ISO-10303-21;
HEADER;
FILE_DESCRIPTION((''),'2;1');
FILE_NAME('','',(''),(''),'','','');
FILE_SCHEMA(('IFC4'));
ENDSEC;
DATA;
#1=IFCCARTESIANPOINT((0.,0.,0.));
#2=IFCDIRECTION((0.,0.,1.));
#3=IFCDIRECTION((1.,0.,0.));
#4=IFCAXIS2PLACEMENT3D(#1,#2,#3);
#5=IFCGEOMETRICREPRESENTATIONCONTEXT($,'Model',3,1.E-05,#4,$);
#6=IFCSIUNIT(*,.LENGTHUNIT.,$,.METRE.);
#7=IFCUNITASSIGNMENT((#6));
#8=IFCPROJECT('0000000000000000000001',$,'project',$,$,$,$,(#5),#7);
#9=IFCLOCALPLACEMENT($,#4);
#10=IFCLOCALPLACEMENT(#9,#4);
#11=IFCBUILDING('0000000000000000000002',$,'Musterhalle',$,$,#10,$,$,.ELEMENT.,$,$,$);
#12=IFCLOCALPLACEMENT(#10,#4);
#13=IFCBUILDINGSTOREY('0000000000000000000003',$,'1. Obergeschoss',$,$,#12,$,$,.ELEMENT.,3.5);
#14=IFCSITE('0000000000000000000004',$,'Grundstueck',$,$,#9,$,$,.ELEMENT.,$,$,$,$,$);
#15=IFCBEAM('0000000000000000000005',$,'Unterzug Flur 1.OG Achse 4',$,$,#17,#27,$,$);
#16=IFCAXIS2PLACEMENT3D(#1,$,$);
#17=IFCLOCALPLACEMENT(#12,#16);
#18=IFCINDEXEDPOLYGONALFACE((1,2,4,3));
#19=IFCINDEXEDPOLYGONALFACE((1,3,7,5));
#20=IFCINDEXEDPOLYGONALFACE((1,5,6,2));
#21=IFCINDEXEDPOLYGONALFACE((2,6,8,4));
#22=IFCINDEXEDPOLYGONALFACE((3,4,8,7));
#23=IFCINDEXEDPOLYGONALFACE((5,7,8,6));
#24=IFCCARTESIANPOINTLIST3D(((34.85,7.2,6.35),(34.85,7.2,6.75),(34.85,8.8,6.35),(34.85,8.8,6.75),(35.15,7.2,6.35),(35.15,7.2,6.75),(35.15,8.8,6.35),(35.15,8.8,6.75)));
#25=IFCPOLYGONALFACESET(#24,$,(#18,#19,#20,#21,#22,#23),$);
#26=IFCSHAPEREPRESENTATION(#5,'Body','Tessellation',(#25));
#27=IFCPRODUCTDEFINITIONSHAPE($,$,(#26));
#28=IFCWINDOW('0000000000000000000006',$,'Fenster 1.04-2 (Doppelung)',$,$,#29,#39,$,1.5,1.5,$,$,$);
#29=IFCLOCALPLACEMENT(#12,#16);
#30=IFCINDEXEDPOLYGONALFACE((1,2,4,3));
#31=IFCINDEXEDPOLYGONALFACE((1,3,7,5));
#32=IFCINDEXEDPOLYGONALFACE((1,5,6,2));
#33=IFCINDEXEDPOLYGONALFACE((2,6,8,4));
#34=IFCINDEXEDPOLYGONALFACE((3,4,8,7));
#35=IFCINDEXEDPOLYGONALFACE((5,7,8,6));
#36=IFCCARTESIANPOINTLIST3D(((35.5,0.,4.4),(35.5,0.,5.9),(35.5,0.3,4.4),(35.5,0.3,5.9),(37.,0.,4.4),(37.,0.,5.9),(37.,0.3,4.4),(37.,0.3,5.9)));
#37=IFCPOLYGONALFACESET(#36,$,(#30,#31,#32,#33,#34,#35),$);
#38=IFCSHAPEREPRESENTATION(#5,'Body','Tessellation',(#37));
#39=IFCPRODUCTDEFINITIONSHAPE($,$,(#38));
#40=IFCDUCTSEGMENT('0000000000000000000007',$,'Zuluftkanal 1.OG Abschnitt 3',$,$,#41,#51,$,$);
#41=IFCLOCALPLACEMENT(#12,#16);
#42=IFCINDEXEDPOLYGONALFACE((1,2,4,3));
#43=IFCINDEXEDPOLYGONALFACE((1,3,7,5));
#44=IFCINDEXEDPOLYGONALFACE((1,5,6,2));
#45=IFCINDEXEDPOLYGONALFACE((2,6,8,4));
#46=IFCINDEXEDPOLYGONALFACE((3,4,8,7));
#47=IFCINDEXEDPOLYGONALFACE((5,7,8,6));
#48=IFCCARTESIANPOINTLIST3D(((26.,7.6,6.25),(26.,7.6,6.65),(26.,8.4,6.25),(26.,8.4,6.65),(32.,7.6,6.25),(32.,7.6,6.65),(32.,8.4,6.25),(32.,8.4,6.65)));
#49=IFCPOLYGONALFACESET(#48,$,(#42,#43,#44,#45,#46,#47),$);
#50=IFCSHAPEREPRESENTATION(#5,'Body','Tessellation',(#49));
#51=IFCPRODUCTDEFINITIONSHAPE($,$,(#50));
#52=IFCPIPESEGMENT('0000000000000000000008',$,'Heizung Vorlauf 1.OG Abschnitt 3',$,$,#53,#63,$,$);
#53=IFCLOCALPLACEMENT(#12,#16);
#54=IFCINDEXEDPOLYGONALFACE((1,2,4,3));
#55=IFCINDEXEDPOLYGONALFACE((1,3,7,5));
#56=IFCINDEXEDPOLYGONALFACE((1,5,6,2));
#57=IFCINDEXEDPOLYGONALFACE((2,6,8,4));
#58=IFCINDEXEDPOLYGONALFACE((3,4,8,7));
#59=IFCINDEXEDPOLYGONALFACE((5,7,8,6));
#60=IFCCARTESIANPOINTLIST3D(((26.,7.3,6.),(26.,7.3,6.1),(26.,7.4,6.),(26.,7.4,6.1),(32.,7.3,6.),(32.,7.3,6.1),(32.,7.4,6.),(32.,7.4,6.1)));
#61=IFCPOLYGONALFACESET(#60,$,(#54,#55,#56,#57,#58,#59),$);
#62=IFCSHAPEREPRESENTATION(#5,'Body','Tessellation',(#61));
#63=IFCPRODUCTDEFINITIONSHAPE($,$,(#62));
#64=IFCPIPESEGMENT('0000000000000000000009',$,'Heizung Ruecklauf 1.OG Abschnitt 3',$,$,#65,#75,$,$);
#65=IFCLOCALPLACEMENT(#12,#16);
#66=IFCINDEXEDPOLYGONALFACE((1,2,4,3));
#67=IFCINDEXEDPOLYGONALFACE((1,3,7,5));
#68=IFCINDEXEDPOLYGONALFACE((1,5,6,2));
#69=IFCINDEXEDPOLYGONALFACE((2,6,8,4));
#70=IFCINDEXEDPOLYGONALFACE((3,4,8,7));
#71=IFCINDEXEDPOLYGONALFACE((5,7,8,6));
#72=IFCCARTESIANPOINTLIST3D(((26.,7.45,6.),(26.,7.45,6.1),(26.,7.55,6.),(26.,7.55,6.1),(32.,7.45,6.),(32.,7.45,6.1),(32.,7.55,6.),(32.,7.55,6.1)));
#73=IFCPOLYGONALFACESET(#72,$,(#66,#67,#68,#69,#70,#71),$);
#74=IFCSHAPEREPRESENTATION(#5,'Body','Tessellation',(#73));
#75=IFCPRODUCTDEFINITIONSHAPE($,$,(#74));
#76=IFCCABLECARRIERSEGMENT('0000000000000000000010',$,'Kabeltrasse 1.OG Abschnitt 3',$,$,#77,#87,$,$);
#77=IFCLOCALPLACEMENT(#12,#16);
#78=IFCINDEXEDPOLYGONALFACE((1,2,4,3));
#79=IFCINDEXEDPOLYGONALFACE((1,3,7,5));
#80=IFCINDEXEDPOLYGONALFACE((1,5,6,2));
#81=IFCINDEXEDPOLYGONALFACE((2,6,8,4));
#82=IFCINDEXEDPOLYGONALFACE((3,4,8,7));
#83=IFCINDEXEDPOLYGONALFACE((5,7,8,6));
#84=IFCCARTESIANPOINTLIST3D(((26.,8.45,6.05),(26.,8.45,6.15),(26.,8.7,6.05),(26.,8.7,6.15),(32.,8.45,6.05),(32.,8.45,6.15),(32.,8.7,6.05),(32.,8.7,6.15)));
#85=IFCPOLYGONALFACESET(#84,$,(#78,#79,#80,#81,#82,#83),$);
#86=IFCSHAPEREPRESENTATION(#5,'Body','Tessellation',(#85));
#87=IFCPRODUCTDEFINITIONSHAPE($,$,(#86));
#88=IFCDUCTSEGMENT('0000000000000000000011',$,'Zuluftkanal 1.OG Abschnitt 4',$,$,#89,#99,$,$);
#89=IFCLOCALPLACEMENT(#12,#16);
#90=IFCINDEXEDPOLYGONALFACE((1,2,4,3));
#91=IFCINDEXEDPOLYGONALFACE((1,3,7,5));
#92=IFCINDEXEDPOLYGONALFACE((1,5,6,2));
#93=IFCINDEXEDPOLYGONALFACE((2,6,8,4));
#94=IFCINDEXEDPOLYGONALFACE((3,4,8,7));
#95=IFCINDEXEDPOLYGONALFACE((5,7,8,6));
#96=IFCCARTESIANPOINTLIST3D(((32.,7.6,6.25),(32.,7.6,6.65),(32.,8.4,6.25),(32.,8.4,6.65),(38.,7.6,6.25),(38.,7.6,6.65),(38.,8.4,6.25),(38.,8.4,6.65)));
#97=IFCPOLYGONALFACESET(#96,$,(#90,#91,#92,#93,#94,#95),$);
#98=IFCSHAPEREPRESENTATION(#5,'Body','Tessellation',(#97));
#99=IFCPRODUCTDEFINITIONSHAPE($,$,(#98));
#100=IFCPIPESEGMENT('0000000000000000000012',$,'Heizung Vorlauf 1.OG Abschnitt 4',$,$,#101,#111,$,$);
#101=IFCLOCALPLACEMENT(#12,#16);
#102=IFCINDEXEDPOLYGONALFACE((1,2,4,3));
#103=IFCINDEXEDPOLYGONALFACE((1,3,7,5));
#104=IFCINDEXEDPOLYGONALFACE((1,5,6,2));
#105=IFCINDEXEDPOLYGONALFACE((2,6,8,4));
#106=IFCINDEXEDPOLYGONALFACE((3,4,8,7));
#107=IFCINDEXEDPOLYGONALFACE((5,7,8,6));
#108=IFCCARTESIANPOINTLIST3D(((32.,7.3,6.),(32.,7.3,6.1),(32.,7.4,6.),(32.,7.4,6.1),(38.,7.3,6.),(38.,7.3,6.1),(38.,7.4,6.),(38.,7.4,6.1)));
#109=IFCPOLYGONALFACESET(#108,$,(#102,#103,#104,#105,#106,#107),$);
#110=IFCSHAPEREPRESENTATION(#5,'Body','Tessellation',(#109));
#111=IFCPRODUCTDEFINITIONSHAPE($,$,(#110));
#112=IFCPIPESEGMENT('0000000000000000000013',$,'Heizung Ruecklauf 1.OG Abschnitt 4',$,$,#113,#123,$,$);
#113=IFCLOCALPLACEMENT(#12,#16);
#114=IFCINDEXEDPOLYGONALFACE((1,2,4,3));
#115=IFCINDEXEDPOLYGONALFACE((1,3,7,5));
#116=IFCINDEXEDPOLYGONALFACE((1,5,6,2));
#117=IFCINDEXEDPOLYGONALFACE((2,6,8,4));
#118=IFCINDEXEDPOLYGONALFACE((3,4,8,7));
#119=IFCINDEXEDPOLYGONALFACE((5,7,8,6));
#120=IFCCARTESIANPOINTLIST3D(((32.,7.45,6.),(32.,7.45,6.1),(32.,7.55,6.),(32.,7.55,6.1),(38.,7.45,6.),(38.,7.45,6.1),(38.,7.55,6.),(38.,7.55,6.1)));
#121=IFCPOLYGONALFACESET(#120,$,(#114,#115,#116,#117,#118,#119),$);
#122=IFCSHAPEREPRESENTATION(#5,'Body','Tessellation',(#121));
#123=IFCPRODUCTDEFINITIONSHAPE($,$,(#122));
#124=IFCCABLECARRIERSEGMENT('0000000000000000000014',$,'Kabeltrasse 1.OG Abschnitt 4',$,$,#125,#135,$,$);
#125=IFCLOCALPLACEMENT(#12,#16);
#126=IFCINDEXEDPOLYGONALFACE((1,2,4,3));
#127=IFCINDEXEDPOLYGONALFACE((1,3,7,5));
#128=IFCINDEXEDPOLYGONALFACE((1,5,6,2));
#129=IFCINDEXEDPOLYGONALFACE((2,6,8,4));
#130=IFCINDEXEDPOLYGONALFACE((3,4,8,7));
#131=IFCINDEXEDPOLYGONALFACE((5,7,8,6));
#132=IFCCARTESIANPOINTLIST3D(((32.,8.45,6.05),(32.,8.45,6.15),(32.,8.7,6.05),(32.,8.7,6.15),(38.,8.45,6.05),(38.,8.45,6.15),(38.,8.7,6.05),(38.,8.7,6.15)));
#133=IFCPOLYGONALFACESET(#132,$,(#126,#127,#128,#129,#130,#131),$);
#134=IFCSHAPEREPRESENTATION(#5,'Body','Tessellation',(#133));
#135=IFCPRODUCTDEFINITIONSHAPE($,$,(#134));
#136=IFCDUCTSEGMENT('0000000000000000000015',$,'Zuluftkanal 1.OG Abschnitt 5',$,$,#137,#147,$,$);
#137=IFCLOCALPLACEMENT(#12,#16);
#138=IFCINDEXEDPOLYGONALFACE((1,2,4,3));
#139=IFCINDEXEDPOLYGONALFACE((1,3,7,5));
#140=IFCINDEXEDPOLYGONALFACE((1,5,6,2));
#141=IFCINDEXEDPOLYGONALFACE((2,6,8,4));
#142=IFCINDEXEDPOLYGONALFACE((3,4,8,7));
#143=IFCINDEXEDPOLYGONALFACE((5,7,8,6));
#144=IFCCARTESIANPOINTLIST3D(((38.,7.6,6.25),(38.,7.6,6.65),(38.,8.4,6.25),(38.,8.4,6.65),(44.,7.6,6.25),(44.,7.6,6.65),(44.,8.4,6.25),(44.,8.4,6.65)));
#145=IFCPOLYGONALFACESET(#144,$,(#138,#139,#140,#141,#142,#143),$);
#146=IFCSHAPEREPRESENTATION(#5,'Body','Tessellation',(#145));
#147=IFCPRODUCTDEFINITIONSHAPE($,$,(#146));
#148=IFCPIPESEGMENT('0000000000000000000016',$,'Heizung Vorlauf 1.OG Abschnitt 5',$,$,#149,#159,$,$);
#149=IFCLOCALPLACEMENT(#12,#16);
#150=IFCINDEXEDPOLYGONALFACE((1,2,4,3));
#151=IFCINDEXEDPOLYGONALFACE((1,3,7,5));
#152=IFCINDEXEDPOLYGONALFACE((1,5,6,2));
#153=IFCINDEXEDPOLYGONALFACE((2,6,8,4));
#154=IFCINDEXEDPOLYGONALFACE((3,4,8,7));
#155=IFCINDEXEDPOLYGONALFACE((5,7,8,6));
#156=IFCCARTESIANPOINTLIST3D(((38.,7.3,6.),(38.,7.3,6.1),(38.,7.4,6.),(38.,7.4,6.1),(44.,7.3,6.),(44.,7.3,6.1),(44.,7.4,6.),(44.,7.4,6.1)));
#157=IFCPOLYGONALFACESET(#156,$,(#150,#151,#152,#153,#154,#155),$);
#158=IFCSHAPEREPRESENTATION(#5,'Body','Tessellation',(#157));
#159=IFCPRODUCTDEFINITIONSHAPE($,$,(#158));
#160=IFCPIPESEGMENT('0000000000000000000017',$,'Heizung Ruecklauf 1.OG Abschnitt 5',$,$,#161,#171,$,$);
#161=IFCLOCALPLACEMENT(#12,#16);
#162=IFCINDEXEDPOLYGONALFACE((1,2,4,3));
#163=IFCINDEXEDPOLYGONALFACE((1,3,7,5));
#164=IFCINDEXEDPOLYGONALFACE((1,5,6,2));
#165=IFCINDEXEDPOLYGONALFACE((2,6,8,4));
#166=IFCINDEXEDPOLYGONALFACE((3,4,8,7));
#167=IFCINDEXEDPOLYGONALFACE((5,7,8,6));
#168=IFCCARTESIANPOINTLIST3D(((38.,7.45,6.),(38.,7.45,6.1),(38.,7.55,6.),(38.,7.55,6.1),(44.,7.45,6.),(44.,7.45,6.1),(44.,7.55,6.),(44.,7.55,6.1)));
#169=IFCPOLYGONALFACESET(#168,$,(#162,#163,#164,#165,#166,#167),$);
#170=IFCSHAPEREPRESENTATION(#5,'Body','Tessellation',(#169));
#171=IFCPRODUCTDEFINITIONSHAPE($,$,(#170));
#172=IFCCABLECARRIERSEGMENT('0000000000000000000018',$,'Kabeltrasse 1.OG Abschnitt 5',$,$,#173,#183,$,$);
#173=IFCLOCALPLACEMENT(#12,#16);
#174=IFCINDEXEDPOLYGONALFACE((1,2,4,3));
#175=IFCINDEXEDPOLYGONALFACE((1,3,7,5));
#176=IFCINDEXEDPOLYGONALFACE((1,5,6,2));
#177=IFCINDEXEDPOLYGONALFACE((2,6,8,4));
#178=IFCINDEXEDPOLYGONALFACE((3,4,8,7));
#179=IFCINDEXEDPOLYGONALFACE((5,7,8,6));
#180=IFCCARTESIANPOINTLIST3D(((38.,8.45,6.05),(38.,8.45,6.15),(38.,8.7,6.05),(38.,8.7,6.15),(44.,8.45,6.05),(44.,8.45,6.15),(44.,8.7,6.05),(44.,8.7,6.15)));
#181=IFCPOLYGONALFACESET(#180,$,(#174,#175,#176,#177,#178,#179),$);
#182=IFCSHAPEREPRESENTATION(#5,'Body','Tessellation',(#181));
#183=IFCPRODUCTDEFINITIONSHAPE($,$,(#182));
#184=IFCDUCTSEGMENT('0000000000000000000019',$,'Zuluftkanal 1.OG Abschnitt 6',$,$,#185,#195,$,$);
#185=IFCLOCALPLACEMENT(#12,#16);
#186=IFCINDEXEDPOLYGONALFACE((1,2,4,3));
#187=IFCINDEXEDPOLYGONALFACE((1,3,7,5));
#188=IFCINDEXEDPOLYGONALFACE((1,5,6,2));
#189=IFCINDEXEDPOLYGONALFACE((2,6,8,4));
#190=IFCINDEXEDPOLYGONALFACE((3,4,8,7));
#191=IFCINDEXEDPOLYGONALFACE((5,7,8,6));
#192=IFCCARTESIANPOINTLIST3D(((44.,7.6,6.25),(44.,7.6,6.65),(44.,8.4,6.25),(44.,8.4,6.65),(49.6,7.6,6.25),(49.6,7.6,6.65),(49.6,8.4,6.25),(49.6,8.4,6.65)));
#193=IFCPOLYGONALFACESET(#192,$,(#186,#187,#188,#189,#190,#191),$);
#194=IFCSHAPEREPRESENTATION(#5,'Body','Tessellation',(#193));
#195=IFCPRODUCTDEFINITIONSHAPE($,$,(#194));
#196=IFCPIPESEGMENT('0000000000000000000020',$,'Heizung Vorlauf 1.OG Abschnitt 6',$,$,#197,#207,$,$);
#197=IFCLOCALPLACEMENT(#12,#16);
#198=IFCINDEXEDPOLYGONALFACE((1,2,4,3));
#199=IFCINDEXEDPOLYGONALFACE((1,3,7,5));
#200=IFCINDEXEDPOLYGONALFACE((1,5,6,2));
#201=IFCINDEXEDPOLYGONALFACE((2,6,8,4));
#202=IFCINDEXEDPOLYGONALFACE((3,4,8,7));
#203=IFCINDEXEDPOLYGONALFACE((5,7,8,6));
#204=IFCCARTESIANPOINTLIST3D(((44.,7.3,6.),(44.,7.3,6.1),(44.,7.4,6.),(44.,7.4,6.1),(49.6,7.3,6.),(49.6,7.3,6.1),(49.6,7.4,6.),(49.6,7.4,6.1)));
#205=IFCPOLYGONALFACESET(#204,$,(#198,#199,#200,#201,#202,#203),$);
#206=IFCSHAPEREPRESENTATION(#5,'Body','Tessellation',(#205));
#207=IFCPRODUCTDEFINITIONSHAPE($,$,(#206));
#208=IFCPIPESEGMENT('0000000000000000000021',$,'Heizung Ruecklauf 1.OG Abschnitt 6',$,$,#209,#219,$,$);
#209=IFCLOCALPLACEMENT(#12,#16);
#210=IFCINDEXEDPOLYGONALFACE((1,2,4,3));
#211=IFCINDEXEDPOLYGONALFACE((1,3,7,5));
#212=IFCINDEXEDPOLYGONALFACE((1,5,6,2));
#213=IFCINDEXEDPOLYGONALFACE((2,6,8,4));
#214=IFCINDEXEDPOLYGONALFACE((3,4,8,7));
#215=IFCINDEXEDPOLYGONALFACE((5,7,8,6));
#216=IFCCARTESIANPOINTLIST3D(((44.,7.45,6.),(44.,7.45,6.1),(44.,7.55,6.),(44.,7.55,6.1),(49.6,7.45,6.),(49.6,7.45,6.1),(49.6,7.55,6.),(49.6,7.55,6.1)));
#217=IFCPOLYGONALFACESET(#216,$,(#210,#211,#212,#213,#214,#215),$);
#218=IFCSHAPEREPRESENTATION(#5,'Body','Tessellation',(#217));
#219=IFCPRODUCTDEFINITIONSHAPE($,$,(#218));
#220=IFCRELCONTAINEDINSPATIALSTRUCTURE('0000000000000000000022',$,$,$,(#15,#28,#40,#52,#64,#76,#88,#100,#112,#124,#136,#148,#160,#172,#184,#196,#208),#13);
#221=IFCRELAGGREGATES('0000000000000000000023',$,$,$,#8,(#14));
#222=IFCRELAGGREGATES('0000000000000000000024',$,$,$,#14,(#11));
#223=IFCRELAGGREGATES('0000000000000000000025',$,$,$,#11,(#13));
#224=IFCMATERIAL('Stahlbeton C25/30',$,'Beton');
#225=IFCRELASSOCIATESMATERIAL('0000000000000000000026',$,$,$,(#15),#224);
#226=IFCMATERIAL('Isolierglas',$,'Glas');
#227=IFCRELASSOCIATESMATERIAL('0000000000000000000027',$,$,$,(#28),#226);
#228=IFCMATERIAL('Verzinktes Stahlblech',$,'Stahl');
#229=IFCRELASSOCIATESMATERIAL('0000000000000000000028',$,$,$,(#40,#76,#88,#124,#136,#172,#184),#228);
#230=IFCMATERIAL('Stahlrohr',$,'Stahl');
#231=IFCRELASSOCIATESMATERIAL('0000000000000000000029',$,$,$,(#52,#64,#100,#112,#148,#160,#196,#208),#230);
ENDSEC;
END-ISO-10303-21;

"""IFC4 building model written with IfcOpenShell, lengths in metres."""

from ifc_helpers import new_model, si_unit, frame, origin_with_axes, origin_2d, place, context, project, spatial, rectangle, extrude, material, element, save


model = new_model("IFC4")

# Units and contexts
model_context = context("Model", 3, precision=1e-05, world=origin_with_axes())
ifc_project = project(units=[si_unit("LENGTHUNIT", "METRE")], contexts=[model_context])

# Site, building, storey
site_placement = place(None, origin_with_axes())
site = spatial("IfcSite", under=ifc_project, at=site_placement, Name="Grundstueck", CompositionType="ELEMENT")
building_placement = place(site_placement, origin_with_axes())
building = spatial("IfcBuilding", under=site, at=building_placement, Name="Musterhalle", CompositionType="ELEMENT")
storey_placement = place(building_placement, origin_with_axes())
storey = spatial("IfcBuildingStorey", under=building, at=storey_placement, Name="1. Obergeschoss", CompositionType="ELEMENT", Elevation=3.5)

# Beam
ifc_material_1 = material(Name="Stahlbeton C25/30", Category="Beton")
placement = place(storey_placement, origin_with_axes())
element("IfcBeam", 1, at=placement, inside=storey, material=ifc_material_1, Name="Unterzug Flur 1.OG Achse 4", context=model_context, shape_type="SweptSolid", body=[
    extrude(rectangle(XDim=0.3, YDim=1.6, at=origin_2d()), frame((35.0, 8.0, 6.35), z_axis=(0.0, 0.0, 1.0), x_axis=(1.0, 0.0, 0.0)), (0.0, 0.0, 1.0), 0.4),
])

# Window
ifc_material_2 = material(Name="Isolierglas", Category="Glas")
element("IfcWindow", 2, at=placement, inside=storey, material=ifc_material_2, Name="Fenster 1.04-2 (Doppelung)", OverallHeight=1.5, OverallWidth=1.5, context=model_context, shape_type="SweptSolid", body=[
    extrude(rectangle(XDim=1.5, YDim=0.3, at=origin_2d()), frame((36.25, 0.15, 4.4), z_axis=(0.0, 0.0, 1.0), x_axis=(1.0, 0.0, 0.0)), (0.0, 0.0, 1.0), 1.5),
])

# Duct segment
ifc_material_3 = material(Name="Verzinktes Stahlblech", Category="Stahl")
element("IfcDuctSegment", 3, at=placement, inside=storey, material=ifc_material_3, Name="Zuluftkanal 1.OG Abschnitt 3", context=model_context, shape_type="SweptSolid", body=[
    extrude(rectangle(XDim=6.0, YDim=0.8, at=origin_2d()), frame((29.0, 8.0, 6.25), z_axis=(0.0, 0.0, 1.0), x_axis=(1.0, 0.0, 0.0)), (0.0, 0.0, 1.0), 0.4),
])

# Pipe segments
ifc_material_4 = material(Name="Stahlrohr", Category="Stahl")
element("IfcPipeSegment", 4, at=placement, inside=storey, material=ifc_material_4, Name="Heizung Vorlauf 1.OG Abschnitt 3", context=model_context, shape_type="SweptSolid", body=[
    extrude(rectangle(XDim=6.0, YDim=0.1, at=origin_2d()), frame((29.0, 7.35, 6.0), z_axis=(0.0, 0.0, 1.0), x_axis=(1.0, 0.0, 0.0)), (0.0, 0.0, 1.0), 0.1),
])
element("IfcPipeSegment", 5, at=placement, inside=storey, material=ifc_material_4, Name="Heizung Ruecklauf 1.OG Abschnitt 3", context=model_context, shape_type="SweptSolid", body=[
    extrude(rectangle(XDim=6.0, YDim=0.1, at=origin_2d()), frame((29.0, 7.5, 6.0), z_axis=(0.0, 0.0, 1.0), x_axis=(1.0, 0.0, 0.0)), (0.0, 0.0, 1.0), 0.1),
])

# Cable carrier segment
element("IfcCableCarrierSegment", 6, at=placement, inside=storey, material=ifc_material_3, Name="Kabeltrasse 1.OG Abschnitt 3", context=model_context, shape_type="SweptSolid", body=[
    extrude(rectangle(XDim=6.0, YDim=0.25, at=origin_2d()), frame((29.0, 8.575, 6.05), z_axis=(0.0, 0.0, 1.0), x_axis=(1.0, 0.0, 0.0)), (0.0, 0.0, 1.0), 0.1),
])

# Duct segment
element("IfcDuctSegment", 7, at=placement, inside=storey, material=ifc_material_3, Name="Zuluftkanal 1.OG Abschnitt 4", context=model_context, shape_type="SweptSolid", body=[
    extrude(rectangle(XDim=6.0, YDim=0.8, at=origin_2d()), frame((35.0, 8.0, 6.25), z_axis=(0.0, 0.0, 1.0), x_axis=(1.0, 0.0, 0.0)), (0.0, 0.0, 1.0), 0.4),
])

# Pipe segments
element("IfcPipeSegment", 8, at=placement, inside=storey, material=ifc_material_4, Name="Heizung Vorlauf 1.OG Abschnitt 4", context=model_context, shape_type="SweptSolid", body=[
    extrude(rectangle(XDim=6.0, YDim=0.1, at=origin_2d()), frame((35.0, 7.35, 6.0), z_axis=(0.0, 0.0, 1.0), x_axis=(1.0, 0.0, 0.0)), (0.0, 0.0, 1.0), 0.1),
])
element("IfcPipeSegment", 9, at=placement, inside=storey, material=ifc_material_4, Name="Heizung Ruecklauf 1.OG Abschnitt 4", context=model_context, shape_type="SweptSolid", body=[
    extrude(rectangle(XDim=6.0, YDim=0.1, at=origin_2d()), frame((35.0, 7.5, 6.0), z_axis=(0.0, 0.0, 1.0), x_axis=(1.0, 0.0, 0.0)), (0.0, 0.0, 1.0), 0.1),
])

# Cable carrier segment
element("IfcCableCarrierSegment", 10, at=placement, inside=storey, material=ifc_material_3, Name="Kabeltrasse 1.OG Abschnitt 4", context=model_context, shape_type="SweptSolid", body=[
    extrude(rectangle(XDim=6.0, YDim=0.25, at=origin_2d()), frame((35.0, 8.575, 6.05), z_axis=(0.0, 0.0, 1.0), x_axis=(1.0, 0.0, 0.0)), (0.0, 0.0, 1.0), 0.1),
])

# Duct segment
element("IfcDuctSegment", 11, at=placement, inside=storey, material=ifc_material_3, Name="Zuluftkanal 1.OG Abschnitt 5", context=model_context, shape_type="SweptSolid", body=[
    extrude(rectangle(XDim=6.0, YDim=0.8, at=origin_2d()), frame((41.0, 8.0, 6.25), z_axis=(0.0, 0.0, 1.0), x_axis=(1.0, 0.0, 0.0)), (0.0, 0.0, 1.0), 0.4),
])

# Pipe segments
element("IfcPipeSegment", 12, at=placement, inside=storey, material=ifc_material_4, Name="Heizung Vorlauf 1.OG Abschnitt 5", context=model_context, shape_type="SweptSolid", body=[
    extrude(rectangle(XDim=6.0, YDim=0.1, at=origin_2d()), frame((41.0, 7.35, 6.0), z_axis=(0.0, 0.0, 1.0), x_axis=(1.0, 0.0, 0.0)), (0.0, 0.0, 1.0), 0.1),
])
element("IfcPipeSegment", 13, at=placement, inside=storey, material=ifc_material_4, Name="Heizung Ruecklauf 1.OG Abschnitt 5", context=model_context, shape_type="SweptSolid", body=[
    extrude(rectangle(XDim=6.0, YDim=0.1, at=origin_2d()), frame((41.0, 7.5, 6.0), z_axis=(0.0, 0.0, 1.0), x_axis=(1.0, 0.0, 0.0)), (0.0, 0.0, 1.0), 0.1),
])

# Cable carrier segment
element("IfcCableCarrierSegment", 14, at=placement, inside=storey, material=ifc_material_3, Name="Kabeltrasse 1.OG Abschnitt 5", context=model_context, shape_type="SweptSolid", body=[
    extrude(rectangle(XDim=6.0, YDim=0.25, at=origin_2d()), frame((41.0, 8.575, 6.05), z_axis=(0.0, 0.0, 1.0), x_axis=(1.0, 0.0, 0.0)), (0.0, 0.0, 1.0), 0.1),
])

# Duct segment
element("IfcDuctSegment", 15, at=placement, inside=storey, material=ifc_material_3, Name="Zuluftkanal 1.OG Abschnitt 6", context=model_context, shape_type="SweptSolid", body=[
    extrude(rectangle(XDim=5.6, YDim=0.8, at=origin_2d()), frame((46.8, 8.0, 6.25), z_axis=(0.0, 0.0, 1.0), x_axis=(1.0, 0.0, 0.0)), (0.0, 0.0, 1.0), 0.4),
])

# Pipe segments
element("IfcPipeSegment", 16, at=placement, inside=storey, material=ifc_material_4, Name="Heizung Vorlauf 1.OG Abschnitt 6", context=model_context, shape_type="SweptSolid", body=[
    extrude(rectangle(XDim=5.6, YDim=0.1, at=origin_2d()), frame((46.8, 7.35, 6.0), z_axis=(0.0, 0.0, 1.0), x_axis=(1.0, 0.0, 0.0)), (0.0, 0.0, 1.0), 0.1),
])
element("IfcPipeSegment", 17, at=placement, inside=storey, material=ifc_material_4, Name="Heizung Ruecklauf 1.OG Abschnitt 6", context=model_context, shape_type="SweptSolid", body=[
    extrude(rectangle(XDim=5.6, YDim=0.1, at=origin_2d()), frame((46.8, 7.5, 6.0), z_axis=(0.0, 0.0, 1.0), x_axis=(1.0, 0.0, 0.0)), (0.0, 0.0, 1.0), 0.1),
])

save(model, "model.ifc")
